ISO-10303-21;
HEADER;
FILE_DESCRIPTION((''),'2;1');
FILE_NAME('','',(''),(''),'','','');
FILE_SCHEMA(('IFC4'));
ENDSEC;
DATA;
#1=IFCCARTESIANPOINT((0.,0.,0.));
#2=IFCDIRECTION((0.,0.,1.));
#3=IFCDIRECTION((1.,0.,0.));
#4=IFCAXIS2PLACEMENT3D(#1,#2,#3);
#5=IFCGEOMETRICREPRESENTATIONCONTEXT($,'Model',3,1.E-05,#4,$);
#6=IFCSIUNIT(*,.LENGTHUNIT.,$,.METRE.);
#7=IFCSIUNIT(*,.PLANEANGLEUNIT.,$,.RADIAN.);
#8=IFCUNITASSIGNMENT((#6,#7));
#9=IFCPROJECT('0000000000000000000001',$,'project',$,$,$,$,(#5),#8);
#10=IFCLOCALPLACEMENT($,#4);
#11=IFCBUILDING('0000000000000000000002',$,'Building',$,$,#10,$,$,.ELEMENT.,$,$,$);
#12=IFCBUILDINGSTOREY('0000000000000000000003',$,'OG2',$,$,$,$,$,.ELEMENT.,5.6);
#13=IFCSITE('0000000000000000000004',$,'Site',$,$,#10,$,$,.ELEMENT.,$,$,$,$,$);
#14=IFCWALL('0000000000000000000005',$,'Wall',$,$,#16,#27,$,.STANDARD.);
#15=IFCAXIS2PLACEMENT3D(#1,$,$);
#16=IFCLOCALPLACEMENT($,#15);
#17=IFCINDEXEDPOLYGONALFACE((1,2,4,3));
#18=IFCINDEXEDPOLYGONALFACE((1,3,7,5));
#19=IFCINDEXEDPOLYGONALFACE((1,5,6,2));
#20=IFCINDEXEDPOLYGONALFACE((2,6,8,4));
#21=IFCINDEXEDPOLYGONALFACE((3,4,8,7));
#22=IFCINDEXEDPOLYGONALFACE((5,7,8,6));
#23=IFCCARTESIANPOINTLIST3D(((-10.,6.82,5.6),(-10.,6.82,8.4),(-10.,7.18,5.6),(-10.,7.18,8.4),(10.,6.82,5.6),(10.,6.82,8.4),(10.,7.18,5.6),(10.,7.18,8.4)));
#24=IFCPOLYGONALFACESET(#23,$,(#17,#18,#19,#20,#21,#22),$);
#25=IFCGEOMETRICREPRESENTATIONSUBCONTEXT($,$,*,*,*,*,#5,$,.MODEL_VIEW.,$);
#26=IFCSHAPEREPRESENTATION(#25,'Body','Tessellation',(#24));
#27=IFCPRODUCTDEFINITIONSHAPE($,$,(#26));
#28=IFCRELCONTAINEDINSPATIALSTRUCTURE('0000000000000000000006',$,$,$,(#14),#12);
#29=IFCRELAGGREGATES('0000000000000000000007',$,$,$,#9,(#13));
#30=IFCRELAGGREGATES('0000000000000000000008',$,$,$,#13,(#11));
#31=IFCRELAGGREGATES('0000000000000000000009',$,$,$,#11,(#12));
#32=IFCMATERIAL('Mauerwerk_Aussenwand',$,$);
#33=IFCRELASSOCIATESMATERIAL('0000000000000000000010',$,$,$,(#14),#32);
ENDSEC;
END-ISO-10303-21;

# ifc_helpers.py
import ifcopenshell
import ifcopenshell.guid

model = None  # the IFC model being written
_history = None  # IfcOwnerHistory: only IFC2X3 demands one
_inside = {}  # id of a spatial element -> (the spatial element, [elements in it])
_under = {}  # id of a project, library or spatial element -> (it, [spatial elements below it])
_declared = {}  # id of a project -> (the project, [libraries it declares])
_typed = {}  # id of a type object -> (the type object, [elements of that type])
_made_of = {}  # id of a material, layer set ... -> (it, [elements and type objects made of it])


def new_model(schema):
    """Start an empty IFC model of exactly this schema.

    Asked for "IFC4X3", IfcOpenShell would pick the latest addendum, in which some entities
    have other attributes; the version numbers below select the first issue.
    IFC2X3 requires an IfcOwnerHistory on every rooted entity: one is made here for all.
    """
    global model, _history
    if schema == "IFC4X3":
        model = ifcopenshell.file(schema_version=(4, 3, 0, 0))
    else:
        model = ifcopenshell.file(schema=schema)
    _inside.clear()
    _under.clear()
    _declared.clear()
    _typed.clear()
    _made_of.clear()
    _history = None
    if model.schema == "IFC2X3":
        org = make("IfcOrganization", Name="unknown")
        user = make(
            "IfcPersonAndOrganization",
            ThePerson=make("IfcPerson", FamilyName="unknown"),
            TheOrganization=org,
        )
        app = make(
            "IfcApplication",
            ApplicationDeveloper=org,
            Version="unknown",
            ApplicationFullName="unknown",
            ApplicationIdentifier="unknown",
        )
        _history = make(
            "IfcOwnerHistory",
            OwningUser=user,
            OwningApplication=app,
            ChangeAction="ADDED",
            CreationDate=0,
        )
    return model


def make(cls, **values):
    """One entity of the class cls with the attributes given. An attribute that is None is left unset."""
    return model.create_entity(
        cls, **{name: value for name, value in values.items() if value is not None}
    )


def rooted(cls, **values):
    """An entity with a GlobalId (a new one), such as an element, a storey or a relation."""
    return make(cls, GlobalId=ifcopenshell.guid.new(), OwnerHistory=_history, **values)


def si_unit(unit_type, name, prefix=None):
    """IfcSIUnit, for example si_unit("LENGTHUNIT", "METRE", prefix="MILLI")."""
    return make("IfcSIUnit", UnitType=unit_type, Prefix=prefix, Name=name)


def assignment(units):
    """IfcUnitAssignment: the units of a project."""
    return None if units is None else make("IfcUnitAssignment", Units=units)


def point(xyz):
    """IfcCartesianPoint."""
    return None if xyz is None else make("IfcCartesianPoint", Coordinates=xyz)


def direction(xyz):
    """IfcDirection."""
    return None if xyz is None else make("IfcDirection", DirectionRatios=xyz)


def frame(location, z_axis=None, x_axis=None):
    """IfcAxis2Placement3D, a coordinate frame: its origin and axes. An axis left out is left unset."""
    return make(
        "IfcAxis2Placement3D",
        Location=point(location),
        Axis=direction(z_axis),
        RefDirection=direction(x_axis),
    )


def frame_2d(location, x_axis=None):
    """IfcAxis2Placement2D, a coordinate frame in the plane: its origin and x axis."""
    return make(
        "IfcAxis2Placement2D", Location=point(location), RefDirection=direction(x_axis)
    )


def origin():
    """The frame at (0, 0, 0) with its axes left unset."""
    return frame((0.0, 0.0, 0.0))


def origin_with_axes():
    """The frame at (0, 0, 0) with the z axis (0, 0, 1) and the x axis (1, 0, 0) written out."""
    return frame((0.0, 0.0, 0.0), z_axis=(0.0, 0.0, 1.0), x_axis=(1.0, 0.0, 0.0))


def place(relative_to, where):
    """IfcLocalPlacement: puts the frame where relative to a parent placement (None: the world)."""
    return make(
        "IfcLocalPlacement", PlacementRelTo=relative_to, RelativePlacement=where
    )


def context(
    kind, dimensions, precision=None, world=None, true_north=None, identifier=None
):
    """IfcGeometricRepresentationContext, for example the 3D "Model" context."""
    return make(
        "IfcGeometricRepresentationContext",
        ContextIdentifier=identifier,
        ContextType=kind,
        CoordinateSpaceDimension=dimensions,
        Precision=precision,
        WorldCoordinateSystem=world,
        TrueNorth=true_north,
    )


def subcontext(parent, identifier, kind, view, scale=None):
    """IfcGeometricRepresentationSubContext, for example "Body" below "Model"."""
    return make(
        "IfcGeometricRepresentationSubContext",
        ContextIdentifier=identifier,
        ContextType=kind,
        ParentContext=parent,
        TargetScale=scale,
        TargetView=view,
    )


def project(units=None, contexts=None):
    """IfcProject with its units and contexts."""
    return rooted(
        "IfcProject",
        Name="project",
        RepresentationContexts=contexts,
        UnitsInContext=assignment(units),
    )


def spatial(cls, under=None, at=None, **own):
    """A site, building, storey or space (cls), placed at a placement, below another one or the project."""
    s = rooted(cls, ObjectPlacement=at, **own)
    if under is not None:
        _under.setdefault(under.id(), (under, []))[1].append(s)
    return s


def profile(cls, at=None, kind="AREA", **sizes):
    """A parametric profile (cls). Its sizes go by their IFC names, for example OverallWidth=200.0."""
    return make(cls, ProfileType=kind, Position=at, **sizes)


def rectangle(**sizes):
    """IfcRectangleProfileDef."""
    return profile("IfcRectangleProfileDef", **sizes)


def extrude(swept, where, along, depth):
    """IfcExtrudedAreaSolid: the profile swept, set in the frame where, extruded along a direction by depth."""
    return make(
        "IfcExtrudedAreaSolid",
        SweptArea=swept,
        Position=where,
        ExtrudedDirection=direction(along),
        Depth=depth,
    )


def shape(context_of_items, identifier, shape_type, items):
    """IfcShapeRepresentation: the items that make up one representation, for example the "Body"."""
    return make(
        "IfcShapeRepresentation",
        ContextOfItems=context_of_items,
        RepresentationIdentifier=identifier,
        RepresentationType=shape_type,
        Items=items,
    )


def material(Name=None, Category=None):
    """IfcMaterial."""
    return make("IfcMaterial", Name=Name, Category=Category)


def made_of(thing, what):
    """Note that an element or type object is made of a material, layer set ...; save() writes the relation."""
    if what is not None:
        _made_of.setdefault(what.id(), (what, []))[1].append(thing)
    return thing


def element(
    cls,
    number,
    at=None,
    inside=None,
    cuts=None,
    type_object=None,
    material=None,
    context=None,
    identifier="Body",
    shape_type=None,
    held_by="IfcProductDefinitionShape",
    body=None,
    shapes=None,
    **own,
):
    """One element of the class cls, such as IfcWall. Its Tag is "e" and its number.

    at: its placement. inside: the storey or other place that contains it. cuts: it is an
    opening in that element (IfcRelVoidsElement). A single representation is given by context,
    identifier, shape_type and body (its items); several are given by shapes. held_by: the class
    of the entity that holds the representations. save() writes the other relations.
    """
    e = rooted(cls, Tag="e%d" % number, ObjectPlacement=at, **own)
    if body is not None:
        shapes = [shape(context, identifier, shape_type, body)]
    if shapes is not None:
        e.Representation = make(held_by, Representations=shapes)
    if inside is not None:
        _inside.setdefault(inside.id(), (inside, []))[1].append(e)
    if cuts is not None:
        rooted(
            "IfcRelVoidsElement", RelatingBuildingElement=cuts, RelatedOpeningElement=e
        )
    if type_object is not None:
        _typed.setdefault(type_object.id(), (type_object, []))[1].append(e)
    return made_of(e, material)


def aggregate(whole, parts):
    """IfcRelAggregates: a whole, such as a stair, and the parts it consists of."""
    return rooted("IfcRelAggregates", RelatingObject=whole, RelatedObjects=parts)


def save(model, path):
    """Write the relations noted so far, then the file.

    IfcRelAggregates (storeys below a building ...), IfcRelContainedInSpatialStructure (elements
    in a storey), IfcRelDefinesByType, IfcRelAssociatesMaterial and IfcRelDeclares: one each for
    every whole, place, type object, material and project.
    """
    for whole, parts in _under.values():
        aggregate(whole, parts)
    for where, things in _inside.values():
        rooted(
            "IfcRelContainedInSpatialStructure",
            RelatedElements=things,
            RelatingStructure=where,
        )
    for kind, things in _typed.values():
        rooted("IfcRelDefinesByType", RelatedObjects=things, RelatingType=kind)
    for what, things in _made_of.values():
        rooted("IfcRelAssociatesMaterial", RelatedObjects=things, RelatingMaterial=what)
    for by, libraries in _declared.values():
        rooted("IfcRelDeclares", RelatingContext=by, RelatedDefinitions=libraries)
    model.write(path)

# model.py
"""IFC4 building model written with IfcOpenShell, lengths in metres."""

from ifc_helpers import new_model, si_unit, frame, frame_2d, origin, origin_with_axes, place, context, subcontext, project, spatial, rectangle, extrude, material, element, save


model = new_model("IFC4")

# Units and contexts
model_context = context("Model", 3, precision=1e-05, world=origin_with_axes())
sub_context = subcontext(model_context, None, None, "MODEL_VIEW")
ifc_project = project(units=[si_unit("LENGTHUNIT", "METRE"), si_unit("PLANEANGLEUNIT", "RADIAN")], contexts=[model_context])

# Site, building, storey
placement_1 = place(None, origin_with_axes())
site = spatial("IfcSite", under=ifc_project, at=placement_1, Name="Site", CompositionType="ELEMENT")
building = spatial("IfcBuilding", under=site, at=placement_1, Name="Building", CompositionType="ELEMENT")
storey = spatial("IfcBuildingStorey", under=building, Name="OG2", CompositionType="ELEMENT", Elevation=5.6)

# Wall
ifc_material = material(Name="Mauerwerk_Aussenwand")
placement_2 = place(None, origin_with_axes())
placement_3 = place(placement_2, frame((0.0, 0.0, 5.6)))
wall_placement = place(placement_3, frame((10.0, 7.0, 0.0), x_axis=(-1.0, 0.0, 0.0)))
element("IfcWall", 1, at=wall_placement, inside=storey, material=ifc_material, Name="Wall", PredefinedType="STANDARD", context=sub_context, shape_type="SweptSolid", body=[
    extrude(rectangle(XDim=20.0, YDim=0.36, at=frame_2d((10.0, 0.0))), origin(), (0.0, 0.0, 1.0), 2.8),
])

save(model, "model.ifc")
